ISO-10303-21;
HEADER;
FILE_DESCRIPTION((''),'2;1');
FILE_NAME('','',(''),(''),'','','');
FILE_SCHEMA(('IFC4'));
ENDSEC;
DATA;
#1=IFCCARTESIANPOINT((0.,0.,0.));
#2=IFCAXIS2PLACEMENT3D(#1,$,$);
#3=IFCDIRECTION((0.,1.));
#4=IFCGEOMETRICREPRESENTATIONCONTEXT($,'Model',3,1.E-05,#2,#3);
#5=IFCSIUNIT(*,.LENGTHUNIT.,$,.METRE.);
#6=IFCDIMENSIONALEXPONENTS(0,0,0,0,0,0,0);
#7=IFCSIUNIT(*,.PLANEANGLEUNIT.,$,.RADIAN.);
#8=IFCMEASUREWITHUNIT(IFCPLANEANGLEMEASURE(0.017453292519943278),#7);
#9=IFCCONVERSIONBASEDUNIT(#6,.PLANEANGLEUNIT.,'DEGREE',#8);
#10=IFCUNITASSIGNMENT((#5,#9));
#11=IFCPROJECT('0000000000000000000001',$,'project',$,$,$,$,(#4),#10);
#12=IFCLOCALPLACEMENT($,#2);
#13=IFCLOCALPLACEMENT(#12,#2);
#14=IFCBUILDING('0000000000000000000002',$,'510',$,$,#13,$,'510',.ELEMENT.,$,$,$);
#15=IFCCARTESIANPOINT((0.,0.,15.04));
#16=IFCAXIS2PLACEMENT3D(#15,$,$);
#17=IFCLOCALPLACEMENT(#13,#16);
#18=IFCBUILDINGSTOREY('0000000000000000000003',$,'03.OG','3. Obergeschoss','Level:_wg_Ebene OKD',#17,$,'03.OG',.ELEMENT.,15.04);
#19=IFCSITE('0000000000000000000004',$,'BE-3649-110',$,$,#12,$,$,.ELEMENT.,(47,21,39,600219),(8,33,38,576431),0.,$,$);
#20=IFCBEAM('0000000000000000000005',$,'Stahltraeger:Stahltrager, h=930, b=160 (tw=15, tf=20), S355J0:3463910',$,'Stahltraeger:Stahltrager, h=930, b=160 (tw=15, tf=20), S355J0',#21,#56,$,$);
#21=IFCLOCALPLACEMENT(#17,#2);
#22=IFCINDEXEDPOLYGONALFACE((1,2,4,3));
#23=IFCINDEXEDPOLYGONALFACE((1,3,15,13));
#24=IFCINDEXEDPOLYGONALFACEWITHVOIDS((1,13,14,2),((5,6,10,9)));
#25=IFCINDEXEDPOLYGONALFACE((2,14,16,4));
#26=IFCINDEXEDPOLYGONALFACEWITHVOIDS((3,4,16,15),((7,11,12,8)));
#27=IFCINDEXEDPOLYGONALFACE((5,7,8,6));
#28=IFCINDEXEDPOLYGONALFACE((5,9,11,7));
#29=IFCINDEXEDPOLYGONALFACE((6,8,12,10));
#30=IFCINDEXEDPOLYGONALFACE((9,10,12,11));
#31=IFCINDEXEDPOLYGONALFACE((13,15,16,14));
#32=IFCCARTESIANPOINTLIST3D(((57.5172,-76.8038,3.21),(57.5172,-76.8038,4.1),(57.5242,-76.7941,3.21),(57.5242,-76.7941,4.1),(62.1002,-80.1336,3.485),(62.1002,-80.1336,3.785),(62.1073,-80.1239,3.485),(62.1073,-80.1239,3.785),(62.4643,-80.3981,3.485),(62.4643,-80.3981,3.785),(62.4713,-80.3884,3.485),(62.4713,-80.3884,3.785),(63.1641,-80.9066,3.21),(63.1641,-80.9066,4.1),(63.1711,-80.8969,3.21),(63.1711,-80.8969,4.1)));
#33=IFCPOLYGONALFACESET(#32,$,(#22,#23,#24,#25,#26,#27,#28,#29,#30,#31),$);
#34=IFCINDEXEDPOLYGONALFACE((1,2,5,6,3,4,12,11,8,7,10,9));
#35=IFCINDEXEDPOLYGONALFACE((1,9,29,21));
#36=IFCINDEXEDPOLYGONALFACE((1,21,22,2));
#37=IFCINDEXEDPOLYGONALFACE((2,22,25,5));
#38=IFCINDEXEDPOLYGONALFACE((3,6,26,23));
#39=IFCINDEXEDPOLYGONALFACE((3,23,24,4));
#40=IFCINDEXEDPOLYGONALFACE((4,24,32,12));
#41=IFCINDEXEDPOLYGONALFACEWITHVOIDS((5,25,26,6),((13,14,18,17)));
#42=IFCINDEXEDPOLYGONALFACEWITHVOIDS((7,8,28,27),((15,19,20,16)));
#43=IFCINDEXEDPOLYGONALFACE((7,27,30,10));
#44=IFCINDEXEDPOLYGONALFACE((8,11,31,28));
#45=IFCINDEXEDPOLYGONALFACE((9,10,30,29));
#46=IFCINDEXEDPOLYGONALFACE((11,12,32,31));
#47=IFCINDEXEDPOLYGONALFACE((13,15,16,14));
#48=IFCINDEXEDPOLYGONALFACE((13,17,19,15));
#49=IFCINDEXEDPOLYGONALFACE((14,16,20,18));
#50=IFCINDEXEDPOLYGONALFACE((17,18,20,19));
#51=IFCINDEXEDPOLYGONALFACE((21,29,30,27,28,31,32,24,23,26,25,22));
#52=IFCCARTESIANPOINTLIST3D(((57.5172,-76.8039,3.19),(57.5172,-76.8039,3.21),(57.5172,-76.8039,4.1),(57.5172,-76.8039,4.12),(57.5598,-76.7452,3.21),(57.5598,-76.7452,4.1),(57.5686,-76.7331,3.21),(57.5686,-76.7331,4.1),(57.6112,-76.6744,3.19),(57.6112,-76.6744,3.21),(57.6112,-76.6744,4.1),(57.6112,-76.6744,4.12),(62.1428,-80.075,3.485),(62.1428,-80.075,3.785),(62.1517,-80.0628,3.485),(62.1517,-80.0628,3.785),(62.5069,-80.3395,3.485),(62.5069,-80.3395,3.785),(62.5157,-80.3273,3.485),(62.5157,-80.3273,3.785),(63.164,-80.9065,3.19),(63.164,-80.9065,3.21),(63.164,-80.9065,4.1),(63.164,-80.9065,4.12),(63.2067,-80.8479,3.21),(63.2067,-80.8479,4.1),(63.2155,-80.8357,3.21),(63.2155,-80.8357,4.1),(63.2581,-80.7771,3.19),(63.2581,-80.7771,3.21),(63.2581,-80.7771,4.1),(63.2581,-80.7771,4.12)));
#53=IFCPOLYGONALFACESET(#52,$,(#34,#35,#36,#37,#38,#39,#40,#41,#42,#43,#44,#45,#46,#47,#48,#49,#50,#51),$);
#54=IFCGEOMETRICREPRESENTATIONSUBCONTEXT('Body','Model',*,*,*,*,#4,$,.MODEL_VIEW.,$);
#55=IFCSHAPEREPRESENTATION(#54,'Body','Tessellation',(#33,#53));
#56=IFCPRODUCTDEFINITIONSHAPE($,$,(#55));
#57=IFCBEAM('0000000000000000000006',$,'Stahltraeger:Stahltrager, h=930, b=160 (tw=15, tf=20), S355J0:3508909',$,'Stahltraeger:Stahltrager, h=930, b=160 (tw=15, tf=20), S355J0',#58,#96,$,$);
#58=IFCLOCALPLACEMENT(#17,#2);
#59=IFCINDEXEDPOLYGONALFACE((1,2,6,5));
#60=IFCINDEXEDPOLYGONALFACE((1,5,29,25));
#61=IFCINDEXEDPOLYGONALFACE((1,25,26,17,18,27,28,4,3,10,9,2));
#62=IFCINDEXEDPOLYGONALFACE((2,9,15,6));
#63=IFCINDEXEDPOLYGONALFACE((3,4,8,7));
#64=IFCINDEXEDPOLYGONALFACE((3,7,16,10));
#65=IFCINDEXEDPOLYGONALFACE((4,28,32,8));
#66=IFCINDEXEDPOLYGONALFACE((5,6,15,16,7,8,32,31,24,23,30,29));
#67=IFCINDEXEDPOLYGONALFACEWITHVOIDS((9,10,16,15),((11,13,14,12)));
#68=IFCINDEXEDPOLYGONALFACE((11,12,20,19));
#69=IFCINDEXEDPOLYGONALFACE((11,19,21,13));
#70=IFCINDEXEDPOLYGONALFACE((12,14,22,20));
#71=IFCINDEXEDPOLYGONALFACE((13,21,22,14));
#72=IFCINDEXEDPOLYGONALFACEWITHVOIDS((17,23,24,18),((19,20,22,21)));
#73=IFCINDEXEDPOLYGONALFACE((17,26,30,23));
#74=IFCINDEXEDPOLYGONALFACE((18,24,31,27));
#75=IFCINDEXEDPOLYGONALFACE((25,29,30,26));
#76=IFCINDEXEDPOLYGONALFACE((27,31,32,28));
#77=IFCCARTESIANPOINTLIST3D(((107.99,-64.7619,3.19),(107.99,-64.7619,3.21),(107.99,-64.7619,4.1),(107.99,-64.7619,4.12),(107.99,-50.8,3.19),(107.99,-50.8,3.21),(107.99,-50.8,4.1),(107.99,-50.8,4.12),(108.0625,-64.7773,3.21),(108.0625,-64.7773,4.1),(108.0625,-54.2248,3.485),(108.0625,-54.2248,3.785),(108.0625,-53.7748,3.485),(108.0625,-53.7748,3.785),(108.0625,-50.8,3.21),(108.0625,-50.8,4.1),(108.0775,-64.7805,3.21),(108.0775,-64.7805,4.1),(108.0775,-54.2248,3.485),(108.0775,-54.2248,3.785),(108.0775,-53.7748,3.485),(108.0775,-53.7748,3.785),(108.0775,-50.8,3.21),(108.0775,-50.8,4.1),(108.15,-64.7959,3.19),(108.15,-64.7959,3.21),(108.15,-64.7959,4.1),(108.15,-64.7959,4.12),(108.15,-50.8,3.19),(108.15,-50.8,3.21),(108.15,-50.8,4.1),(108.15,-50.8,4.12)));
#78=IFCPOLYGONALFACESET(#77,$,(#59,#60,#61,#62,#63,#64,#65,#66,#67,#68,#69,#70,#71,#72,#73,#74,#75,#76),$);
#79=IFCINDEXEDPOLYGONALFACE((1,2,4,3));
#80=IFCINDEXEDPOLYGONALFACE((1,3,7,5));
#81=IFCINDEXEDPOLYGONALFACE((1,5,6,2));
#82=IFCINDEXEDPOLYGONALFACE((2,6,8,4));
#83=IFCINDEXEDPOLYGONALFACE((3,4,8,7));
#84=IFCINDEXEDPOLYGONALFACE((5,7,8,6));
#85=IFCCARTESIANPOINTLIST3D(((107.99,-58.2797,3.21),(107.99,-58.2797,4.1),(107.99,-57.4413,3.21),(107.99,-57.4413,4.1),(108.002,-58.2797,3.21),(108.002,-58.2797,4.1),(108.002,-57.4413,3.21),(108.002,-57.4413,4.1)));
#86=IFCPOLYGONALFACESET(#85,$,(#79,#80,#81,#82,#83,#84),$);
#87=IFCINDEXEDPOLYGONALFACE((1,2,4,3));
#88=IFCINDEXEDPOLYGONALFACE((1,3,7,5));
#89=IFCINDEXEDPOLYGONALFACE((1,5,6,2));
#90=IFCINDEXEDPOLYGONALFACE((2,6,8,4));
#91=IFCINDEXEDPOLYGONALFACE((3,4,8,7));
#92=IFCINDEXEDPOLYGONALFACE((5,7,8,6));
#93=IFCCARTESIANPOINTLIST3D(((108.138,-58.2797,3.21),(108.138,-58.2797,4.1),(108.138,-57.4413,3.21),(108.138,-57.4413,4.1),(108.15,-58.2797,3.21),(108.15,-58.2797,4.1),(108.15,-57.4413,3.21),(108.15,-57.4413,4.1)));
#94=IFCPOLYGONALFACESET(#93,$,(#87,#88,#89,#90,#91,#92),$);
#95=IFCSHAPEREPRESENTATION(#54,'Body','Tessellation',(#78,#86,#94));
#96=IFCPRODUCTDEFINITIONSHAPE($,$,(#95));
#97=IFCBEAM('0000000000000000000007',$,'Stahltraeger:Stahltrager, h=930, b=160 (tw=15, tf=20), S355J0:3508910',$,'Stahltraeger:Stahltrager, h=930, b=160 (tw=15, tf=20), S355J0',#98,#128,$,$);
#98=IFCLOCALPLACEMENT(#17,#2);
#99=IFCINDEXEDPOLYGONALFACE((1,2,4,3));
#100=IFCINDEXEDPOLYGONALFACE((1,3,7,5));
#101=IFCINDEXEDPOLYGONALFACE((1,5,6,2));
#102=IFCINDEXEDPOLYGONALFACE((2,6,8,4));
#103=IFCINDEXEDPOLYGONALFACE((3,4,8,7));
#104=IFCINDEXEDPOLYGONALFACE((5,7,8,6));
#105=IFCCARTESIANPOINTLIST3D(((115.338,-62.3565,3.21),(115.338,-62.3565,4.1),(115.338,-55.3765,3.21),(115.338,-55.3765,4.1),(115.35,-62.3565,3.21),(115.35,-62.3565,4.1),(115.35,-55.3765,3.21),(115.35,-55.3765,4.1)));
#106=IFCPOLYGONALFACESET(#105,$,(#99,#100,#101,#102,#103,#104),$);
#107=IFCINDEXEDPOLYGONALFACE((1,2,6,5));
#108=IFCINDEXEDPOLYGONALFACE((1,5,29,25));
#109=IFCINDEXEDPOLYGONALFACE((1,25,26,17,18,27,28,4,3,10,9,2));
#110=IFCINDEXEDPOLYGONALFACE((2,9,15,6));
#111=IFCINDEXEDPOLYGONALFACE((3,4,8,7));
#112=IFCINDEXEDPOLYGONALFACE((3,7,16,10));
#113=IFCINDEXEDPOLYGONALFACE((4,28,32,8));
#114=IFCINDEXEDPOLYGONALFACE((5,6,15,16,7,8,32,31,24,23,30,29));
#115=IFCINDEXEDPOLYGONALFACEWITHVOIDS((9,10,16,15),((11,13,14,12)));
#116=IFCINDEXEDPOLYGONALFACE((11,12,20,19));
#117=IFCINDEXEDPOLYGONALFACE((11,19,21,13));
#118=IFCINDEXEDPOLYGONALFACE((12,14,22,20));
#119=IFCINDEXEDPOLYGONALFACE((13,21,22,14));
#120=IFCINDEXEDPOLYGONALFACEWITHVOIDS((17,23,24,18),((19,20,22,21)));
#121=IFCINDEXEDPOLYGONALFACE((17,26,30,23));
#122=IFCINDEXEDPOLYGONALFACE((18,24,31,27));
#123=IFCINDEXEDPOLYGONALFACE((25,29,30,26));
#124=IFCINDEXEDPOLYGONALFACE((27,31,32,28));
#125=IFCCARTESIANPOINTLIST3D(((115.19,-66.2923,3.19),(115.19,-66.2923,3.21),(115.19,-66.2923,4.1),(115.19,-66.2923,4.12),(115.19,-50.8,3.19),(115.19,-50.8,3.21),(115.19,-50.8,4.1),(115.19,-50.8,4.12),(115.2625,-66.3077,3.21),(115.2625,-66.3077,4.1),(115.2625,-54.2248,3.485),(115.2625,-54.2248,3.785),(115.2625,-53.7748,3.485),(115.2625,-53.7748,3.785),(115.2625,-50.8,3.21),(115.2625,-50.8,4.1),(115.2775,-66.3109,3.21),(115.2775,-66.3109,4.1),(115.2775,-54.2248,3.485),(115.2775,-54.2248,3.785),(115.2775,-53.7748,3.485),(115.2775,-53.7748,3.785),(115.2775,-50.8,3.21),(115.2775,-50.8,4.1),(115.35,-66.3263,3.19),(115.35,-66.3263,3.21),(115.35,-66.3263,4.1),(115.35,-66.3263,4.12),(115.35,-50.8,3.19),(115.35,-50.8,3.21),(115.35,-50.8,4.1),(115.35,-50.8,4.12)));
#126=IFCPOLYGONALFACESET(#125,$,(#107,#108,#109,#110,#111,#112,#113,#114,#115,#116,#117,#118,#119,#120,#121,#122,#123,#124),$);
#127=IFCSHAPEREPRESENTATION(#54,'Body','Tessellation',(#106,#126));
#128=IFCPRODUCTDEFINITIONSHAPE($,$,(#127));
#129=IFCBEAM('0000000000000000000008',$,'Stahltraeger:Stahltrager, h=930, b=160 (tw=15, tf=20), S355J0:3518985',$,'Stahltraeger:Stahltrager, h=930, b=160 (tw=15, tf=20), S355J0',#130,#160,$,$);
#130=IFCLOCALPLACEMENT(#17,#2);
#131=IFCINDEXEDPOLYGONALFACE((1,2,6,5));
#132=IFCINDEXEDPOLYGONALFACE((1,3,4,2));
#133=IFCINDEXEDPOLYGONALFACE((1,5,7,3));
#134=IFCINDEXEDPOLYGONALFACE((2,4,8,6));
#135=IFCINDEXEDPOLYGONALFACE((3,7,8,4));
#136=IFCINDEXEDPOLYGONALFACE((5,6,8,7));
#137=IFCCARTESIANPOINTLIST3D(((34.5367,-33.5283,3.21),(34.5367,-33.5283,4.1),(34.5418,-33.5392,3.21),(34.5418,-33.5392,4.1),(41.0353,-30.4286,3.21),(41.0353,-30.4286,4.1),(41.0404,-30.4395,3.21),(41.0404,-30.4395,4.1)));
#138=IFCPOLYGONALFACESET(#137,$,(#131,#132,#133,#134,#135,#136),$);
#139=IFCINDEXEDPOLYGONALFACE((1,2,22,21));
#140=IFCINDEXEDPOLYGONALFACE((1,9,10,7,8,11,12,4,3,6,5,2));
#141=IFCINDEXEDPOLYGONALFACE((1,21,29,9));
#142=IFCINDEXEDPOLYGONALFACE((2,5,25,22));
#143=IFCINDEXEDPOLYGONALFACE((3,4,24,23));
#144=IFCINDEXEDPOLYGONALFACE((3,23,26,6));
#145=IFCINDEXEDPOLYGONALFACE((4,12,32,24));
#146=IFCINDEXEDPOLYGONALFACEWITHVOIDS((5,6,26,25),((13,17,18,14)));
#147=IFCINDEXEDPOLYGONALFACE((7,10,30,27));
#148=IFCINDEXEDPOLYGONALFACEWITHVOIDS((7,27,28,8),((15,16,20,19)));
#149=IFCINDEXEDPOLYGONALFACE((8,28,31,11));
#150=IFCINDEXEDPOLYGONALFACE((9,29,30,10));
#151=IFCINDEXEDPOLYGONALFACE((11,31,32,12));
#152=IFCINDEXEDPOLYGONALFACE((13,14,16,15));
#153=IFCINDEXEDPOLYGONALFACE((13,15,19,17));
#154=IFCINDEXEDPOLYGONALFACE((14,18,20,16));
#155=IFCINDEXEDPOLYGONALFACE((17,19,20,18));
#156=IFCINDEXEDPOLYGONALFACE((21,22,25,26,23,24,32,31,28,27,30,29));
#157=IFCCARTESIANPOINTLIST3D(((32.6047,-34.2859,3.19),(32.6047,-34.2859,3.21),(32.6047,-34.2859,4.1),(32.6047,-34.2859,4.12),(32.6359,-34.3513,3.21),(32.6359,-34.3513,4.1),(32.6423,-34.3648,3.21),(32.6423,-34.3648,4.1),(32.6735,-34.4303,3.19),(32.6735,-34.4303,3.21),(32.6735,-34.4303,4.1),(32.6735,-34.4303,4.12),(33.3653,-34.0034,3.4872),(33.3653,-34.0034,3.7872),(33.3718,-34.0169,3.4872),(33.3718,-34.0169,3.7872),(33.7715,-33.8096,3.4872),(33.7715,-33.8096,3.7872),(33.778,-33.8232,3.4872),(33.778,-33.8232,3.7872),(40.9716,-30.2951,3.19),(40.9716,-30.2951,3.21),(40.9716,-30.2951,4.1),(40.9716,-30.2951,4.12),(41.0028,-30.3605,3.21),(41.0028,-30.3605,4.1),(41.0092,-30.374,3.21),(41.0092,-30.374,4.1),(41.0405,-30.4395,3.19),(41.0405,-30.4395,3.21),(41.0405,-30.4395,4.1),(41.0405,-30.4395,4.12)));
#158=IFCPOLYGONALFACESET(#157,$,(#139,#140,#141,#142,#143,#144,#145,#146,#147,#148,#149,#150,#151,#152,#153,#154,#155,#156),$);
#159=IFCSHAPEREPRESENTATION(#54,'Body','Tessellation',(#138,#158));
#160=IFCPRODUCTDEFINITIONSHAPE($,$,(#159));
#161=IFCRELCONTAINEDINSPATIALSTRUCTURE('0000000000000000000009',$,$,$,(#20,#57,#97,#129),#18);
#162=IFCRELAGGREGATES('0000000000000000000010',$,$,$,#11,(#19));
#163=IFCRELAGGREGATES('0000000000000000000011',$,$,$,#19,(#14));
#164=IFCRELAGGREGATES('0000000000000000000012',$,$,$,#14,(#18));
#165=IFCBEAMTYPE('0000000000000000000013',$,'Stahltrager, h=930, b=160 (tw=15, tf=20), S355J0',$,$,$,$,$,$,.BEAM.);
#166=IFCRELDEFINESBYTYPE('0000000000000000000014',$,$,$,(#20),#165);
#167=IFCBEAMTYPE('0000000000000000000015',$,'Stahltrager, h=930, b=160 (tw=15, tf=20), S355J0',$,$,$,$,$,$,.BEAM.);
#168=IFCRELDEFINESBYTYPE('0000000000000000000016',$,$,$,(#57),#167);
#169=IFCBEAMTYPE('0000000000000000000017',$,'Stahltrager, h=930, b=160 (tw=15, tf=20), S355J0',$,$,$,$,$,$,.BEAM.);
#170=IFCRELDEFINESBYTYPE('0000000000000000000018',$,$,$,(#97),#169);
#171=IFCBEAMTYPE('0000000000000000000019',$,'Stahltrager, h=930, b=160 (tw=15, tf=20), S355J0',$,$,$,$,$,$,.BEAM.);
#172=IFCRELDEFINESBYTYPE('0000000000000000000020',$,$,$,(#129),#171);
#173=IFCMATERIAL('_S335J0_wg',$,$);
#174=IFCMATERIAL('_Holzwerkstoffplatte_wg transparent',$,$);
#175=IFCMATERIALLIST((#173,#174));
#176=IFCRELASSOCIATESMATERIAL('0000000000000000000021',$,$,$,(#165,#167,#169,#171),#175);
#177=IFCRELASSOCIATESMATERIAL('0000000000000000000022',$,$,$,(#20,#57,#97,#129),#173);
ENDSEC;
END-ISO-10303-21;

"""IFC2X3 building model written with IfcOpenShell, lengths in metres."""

from ifc_helpers import new_model, entity, si_unit, converted_unit, direction, frame, frame_2d, origin, place, context, subcontext, project, spatial, rectangle, i_section, extrude, boolean, clip, halfspace, source, transform, mapped, material, material_list, type_object, type_shapes, element, save


model = new_model("IFC2X3")

# Units and contexts
model_context = context("Model", 3, precision=1e-05, world=origin(), true_north=direction((0.0, 1.0)))
body_context = subcontext(model_context, "Body", "Model", "MODEL_VIEW")
ifc_project = project(units=[si_unit("LENGTHUNIT", "METRE"), converted_unit("PLANEANGLEUNIT", "DEGREE", entity("IfcPlaneAngleMeasure", 0.017453292519943278), si_unit("PLANEANGLEUNIT", "RADIAN"), dimensions=[0, 0, 0, 0, 0, 0, 0])], contexts=[model_context])

# Site, building, storey
site_placement = place(None, origin())
site = spatial("IfcSite", under=ifc_project, at=site_placement, Name="BE-3649-110", CompositionType="ELEMENT", RefLatitude=(47, 21, 39, 600219), RefLongitude=(8, 33, 38, 576431), RefElevation=0.0)
building_placement = place(site_placement, origin())
building = spatial("IfcBuilding", under=site, at=building_placement, Name="510", LongName="510", CompositionType="ELEMENT")
storey_placement = place(building_placement, frame((0.0, 0.0, 15.04)))
storey = spatial("IfcBuildingStorey", under=building, at=storey_placement, Name="03.OG", Description="3. Obergeschoss", ObjectType="Level:_wg_Ebene OKD", LongName="03.OG", CompositionType="ELEMENT", Elevation=15.04)

# Beams
ifc_material_1 = material(Name="_S335J0_wg")
ifc_material_2 = material(Name="_Holzwerkstoffplatte_wg transparent")
ifc_material_list = material_list([ifc_material_1, ifc_material_2])
beam_type_1 = type_object("IfcBeamType", Name="Stahltrager, h=930, b=160 (tw=15, tf=20), S355J0", PredefinedType="BEAM", material=ifc_material_list)
shared_shape_1 = source(origin(), body_context, "Body", "SweptSolid", [
    boolean("DIFFERENCE", extrude(rectangle(XDim=0.89, YDim=0.012, at=frame_2d((0.0, 0.0), x_axis=(0.0, 1.0))), frame((57.5207, -76.799, 18.695), z_axis=(0.809017, -0.587785, 0.0), x_axis=(0.587785, 0.809017, 0.0)), (0.0, 0.0, 1.0), 6.98), extrude(rectangle(XDim=0.3, YDim=0.45, at=frame_2d((0.0, 0.0), x_axis=(0.0, 1.0))), frame((62.2823, -80.2659, 18.675), z_axis=(0.587785, 0.809017, 0.0), x_axis=(0.809017, -0.587785, 0.0)), (0.0, 0.0, 1.0), 0.012)),
    boolean("DIFFERENCE", extrude(i_section(OverallWidth=0.16, OverallDepth=0.93, WebThickness=0.015, FlangeThickness=0.02, at=frame_2d((0.0, 0.0), x_axis=(0.0, 1.0))), frame((57.5642, -76.7391, 18.695), z_axis=(0.809017, -0.587785, 0.0), x_axis=(0.0, 0.0, -1.0)), (0.0, 0.0, 1.0), 6.9799), extrude(rectangle(XDim=0.3, YDim=0.45, at=frame_2d((0.0, 0.0), x_axis=(0.0, 1.0))), frame((62.3249, -80.2072, 18.675), z_axis=(0.587785, 0.809017, 0.0), x_axis=(0.809017, -0.587785, 0.0)), (0.0, 0.0, 1.0), 0.015)),
])
type_shapes(beam_type_1, [shared_shape_1])
beam_1_placement = place(storey_placement, frame((0.0, 0.0, -15.04)))
element("IfcBeam", 1, at=beam_1_placement, inside=storey, type_object=beam_type_1, material=ifc_material_1, Name="Stahltraeger:Stahltrager, h=930, b=160 (tw=15, tf=20), S355J0:3463910", ObjectType="Stahltraeger:Stahltrager, h=930, b=160 (tw=15, tf=20), S355J0", context=body_context, shape_type="MappedRepresentation", body=[
    mapped(shared_shape_1, transform((0.0, 0.0, 0.0), scale=1.0)),
])
beam_type_2 = type_object("IfcBeamType", Name="Stahltrager, h=930, b=160 (tw=15, tf=20), S355J0", PredefinedType="BEAM", material=ifc_material_list)
shared_shape_2 = source(origin(), body_context, "Body", "SweptSolid", [
    boolean("DIFFERENCE", clip(extrude(i_section(OverallWidth=0.16, OverallDepth=0.93, WebThickness=0.015, FlangeThickness=0.02, at=frame_2d((0.0, 0.0), x_axis=(1.0, 0.0))), frame((108.07, -50.8, 18.695), z_axis=(0.0, -1.0, 0.0), x_axis=(-1.0, 0.0, 0.0)), (0.0, 0.0, 1.0), 13.9958), halfspace(frame((108.39, -64.8469, -0.22), z_axis=(-0.207912, -0.978148, 0.0), x_axis=(-0.978148, 0.207912, 0.0)), False)), extrude(rectangle(XDim=0.3, YDim=0.45, at=frame_2d((0.0, 0.0), x_axis=(0.0, 1.0))), frame((108.0625, -53.9998, 18.675), z_axis=(1.0, 0.0, 0.0), x_axis=(0.0, -1.0, 0.0)), (0.0, 0.0, 1.0), 0.015)),
    extrude(rectangle(XDim=0.89, YDim=0.012, at=frame_2d((0.0, 0.0), x_axis=(0.0, 1.0))), frame((107.996, -57.4413, 18.695), z_axis=(0.0, -1.0, 0.0), x_axis=(-1.0, 0.0, 0.0)), (0.0, 0.0, 1.0), 0.8385),
    extrude(rectangle(XDim=0.89, YDim=0.012, at=frame_2d((0.0, 0.0), x_axis=(0.0, 1.0))), frame((108.144, -57.4413, 18.695), z_axis=(0.0, -1.0, 0.0), x_axis=(-1.0, 0.0, 0.0)), (0.0, 0.0, 1.0), 0.8385),
])
type_shapes(beam_type_2, [shared_shape_2])
beam_2_placement = place(storey_placement, frame((0.0, 0.0, -15.04)))
element("IfcBeam", 2, at=beam_2_placement, inside=storey, type_object=beam_type_2, material=ifc_material_1, Name="Stahltraeger:Stahltrager, h=930, b=160 (tw=15, tf=20), S355J0:3508909", ObjectType="Stahltraeger:Stahltrager, h=930, b=160 (tw=15, tf=20), S355J0", context=body_context, shape_type="MappedRepresentation", body=[
    mapped(shared_shape_2, transform((0.0, 0.0, 0.0), scale=1.0)),
])
beam_type_3 = type_object("IfcBeamType", Name="Stahltrager, h=930, b=160 (tw=15, tf=20), S355J0", PredefinedType="BEAM", material=ifc_material_list)
shared_shape_3 = source(origin(), body_context, "Body", "SweptSolid", [
    extrude(rectangle(XDim=0.89, YDim=0.012, at=frame_2d((0.0, 0.0), x_axis=(0.0, 1.0))), frame((115.344, -55.3765, 18.695), z_axis=(0.0, -1.0, 0.0), x_axis=(-1.0, 0.0, 0.0)), (0.0, 0.0, 1.0), 6.98),
    boolean("DIFFERENCE", clip(extrude(i_section(OverallWidth=0.16, OverallDepth=0.93, WebThickness=0.015, FlangeThickness=0.02, at=frame_2d((0.0, 0.0), x_axis=(1.0, 0.0))), frame((115.27, -50.8, 18.695), z_axis=(0.0, -1.0, 0.0), x_axis=(-1.0, 0.0, 0.0)), (0.0, 0.0, 1.0), 15.5263), halfspace(frame((115.7261, -66.4062, -0.22), z_axis=(-0.207912, -0.978148, 0.0), x_axis=(-0.978148, 0.207912, 0.0)), False)), extrude(rectangle(XDim=0.3, YDim=0.45, at=frame_2d((0.0, 0.0), x_axis=(0.0, 1.0))), frame((115.2625, -53.9998, 18.675), z_axis=(1.0, 0.0, 0.0), x_axis=(0.0, -1.0, 0.0)), (0.0, 0.0, 1.0), 0.015)),
])
type_shapes(beam_type_3, [shared_shape_3])
beam_3_placement = place(storey_placement, frame((0.0, 0.0, -15.04)))
element("IfcBeam", 3, at=beam_3_placement, inside=storey, type_object=beam_type_3, material=ifc_material_1, Name="Stahltraeger:Stahltrager, h=930, b=160 (tw=15, tf=20), S355J0:3508910", ObjectType="Stahltraeger:Stahltrager, h=930, b=160 (tw=15, tf=20), S355J0", context=body_context, shape_type="MappedRepresentation", body=[
    mapped(shared_shape_3, transform((0.0, 0.0, 0.0), scale=1.0)),
])
beam_type_4 = type_object("IfcBeamType", Name="Stahltrager, h=930, b=160 (tw=15, tf=20), S355J0", PredefinedType="BEAM", material=ifc_material_list)
shared_shape_4 = source(origin(), body_context, "Body", "SweptSolid", [
    extrude(rectangle(XDim=0.89, YDim=0.012, at=frame_2d((0.0, 0.0), x_axis=(1.0, 0.0))), frame((41.0379, -30.4341, 18.695), z_axis=(-0.902585, -0.430511, 0.0), x_axis=(0.0, 0.0, -1.0)), (0.0, 0.0, 1.0), 7.2),
    boolean("DIFFERENCE", extrude(i_section(OverallWidth=0.16, OverallDepth=0.93, WebThickness=0.015, FlangeThickness=0.02, at=frame_2d((0.0, 0.0), x_axis=(0.0, 1.0))), frame((41.006, -30.3673, 18.695), z_axis=(-0.902585, -0.430511, 0.0), x_axis=(0.0, 0.0, -1.0)), (0.0, 0.0, 1.0), 9.2699), extrude(rectangle(XDim=0.3, YDim=0.45, at=frame_2d((0.0, 0.0), x_axis=(0.0, 1.0))), frame((33.5749, -33.92, 18.6772), z_axis=(-0.430511, 0.902585, 0.0), x_axis=(0.902585, 0.430511, 0.0)), (0.0, 0.0, 1.0), 0.015)),
])
type_shapes(beam_type_4, [shared_shape_4])
beam_4_placement = place(storey_placement, frame((0.0, 0.0, -15.04)))
element("IfcBeam", 4, at=beam_4_placement, inside=storey, type_object=beam_type_4, material=ifc_material_1, Name="Stahltraeger:Stahltrager, h=930, b=160 (tw=15, tf=20), S355J0:3518985", ObjectType="Stahltraeger:Stahltrager, h=930, b=160 (tw=15, tf=20), S355J0", context=body_context, shape_type="MappedRepresentation", body=[
    mapped(shared_shape_4, transform((0.0, 0.0, 0.0), scale=1.0)),
])

save(model, "model.ifc")
